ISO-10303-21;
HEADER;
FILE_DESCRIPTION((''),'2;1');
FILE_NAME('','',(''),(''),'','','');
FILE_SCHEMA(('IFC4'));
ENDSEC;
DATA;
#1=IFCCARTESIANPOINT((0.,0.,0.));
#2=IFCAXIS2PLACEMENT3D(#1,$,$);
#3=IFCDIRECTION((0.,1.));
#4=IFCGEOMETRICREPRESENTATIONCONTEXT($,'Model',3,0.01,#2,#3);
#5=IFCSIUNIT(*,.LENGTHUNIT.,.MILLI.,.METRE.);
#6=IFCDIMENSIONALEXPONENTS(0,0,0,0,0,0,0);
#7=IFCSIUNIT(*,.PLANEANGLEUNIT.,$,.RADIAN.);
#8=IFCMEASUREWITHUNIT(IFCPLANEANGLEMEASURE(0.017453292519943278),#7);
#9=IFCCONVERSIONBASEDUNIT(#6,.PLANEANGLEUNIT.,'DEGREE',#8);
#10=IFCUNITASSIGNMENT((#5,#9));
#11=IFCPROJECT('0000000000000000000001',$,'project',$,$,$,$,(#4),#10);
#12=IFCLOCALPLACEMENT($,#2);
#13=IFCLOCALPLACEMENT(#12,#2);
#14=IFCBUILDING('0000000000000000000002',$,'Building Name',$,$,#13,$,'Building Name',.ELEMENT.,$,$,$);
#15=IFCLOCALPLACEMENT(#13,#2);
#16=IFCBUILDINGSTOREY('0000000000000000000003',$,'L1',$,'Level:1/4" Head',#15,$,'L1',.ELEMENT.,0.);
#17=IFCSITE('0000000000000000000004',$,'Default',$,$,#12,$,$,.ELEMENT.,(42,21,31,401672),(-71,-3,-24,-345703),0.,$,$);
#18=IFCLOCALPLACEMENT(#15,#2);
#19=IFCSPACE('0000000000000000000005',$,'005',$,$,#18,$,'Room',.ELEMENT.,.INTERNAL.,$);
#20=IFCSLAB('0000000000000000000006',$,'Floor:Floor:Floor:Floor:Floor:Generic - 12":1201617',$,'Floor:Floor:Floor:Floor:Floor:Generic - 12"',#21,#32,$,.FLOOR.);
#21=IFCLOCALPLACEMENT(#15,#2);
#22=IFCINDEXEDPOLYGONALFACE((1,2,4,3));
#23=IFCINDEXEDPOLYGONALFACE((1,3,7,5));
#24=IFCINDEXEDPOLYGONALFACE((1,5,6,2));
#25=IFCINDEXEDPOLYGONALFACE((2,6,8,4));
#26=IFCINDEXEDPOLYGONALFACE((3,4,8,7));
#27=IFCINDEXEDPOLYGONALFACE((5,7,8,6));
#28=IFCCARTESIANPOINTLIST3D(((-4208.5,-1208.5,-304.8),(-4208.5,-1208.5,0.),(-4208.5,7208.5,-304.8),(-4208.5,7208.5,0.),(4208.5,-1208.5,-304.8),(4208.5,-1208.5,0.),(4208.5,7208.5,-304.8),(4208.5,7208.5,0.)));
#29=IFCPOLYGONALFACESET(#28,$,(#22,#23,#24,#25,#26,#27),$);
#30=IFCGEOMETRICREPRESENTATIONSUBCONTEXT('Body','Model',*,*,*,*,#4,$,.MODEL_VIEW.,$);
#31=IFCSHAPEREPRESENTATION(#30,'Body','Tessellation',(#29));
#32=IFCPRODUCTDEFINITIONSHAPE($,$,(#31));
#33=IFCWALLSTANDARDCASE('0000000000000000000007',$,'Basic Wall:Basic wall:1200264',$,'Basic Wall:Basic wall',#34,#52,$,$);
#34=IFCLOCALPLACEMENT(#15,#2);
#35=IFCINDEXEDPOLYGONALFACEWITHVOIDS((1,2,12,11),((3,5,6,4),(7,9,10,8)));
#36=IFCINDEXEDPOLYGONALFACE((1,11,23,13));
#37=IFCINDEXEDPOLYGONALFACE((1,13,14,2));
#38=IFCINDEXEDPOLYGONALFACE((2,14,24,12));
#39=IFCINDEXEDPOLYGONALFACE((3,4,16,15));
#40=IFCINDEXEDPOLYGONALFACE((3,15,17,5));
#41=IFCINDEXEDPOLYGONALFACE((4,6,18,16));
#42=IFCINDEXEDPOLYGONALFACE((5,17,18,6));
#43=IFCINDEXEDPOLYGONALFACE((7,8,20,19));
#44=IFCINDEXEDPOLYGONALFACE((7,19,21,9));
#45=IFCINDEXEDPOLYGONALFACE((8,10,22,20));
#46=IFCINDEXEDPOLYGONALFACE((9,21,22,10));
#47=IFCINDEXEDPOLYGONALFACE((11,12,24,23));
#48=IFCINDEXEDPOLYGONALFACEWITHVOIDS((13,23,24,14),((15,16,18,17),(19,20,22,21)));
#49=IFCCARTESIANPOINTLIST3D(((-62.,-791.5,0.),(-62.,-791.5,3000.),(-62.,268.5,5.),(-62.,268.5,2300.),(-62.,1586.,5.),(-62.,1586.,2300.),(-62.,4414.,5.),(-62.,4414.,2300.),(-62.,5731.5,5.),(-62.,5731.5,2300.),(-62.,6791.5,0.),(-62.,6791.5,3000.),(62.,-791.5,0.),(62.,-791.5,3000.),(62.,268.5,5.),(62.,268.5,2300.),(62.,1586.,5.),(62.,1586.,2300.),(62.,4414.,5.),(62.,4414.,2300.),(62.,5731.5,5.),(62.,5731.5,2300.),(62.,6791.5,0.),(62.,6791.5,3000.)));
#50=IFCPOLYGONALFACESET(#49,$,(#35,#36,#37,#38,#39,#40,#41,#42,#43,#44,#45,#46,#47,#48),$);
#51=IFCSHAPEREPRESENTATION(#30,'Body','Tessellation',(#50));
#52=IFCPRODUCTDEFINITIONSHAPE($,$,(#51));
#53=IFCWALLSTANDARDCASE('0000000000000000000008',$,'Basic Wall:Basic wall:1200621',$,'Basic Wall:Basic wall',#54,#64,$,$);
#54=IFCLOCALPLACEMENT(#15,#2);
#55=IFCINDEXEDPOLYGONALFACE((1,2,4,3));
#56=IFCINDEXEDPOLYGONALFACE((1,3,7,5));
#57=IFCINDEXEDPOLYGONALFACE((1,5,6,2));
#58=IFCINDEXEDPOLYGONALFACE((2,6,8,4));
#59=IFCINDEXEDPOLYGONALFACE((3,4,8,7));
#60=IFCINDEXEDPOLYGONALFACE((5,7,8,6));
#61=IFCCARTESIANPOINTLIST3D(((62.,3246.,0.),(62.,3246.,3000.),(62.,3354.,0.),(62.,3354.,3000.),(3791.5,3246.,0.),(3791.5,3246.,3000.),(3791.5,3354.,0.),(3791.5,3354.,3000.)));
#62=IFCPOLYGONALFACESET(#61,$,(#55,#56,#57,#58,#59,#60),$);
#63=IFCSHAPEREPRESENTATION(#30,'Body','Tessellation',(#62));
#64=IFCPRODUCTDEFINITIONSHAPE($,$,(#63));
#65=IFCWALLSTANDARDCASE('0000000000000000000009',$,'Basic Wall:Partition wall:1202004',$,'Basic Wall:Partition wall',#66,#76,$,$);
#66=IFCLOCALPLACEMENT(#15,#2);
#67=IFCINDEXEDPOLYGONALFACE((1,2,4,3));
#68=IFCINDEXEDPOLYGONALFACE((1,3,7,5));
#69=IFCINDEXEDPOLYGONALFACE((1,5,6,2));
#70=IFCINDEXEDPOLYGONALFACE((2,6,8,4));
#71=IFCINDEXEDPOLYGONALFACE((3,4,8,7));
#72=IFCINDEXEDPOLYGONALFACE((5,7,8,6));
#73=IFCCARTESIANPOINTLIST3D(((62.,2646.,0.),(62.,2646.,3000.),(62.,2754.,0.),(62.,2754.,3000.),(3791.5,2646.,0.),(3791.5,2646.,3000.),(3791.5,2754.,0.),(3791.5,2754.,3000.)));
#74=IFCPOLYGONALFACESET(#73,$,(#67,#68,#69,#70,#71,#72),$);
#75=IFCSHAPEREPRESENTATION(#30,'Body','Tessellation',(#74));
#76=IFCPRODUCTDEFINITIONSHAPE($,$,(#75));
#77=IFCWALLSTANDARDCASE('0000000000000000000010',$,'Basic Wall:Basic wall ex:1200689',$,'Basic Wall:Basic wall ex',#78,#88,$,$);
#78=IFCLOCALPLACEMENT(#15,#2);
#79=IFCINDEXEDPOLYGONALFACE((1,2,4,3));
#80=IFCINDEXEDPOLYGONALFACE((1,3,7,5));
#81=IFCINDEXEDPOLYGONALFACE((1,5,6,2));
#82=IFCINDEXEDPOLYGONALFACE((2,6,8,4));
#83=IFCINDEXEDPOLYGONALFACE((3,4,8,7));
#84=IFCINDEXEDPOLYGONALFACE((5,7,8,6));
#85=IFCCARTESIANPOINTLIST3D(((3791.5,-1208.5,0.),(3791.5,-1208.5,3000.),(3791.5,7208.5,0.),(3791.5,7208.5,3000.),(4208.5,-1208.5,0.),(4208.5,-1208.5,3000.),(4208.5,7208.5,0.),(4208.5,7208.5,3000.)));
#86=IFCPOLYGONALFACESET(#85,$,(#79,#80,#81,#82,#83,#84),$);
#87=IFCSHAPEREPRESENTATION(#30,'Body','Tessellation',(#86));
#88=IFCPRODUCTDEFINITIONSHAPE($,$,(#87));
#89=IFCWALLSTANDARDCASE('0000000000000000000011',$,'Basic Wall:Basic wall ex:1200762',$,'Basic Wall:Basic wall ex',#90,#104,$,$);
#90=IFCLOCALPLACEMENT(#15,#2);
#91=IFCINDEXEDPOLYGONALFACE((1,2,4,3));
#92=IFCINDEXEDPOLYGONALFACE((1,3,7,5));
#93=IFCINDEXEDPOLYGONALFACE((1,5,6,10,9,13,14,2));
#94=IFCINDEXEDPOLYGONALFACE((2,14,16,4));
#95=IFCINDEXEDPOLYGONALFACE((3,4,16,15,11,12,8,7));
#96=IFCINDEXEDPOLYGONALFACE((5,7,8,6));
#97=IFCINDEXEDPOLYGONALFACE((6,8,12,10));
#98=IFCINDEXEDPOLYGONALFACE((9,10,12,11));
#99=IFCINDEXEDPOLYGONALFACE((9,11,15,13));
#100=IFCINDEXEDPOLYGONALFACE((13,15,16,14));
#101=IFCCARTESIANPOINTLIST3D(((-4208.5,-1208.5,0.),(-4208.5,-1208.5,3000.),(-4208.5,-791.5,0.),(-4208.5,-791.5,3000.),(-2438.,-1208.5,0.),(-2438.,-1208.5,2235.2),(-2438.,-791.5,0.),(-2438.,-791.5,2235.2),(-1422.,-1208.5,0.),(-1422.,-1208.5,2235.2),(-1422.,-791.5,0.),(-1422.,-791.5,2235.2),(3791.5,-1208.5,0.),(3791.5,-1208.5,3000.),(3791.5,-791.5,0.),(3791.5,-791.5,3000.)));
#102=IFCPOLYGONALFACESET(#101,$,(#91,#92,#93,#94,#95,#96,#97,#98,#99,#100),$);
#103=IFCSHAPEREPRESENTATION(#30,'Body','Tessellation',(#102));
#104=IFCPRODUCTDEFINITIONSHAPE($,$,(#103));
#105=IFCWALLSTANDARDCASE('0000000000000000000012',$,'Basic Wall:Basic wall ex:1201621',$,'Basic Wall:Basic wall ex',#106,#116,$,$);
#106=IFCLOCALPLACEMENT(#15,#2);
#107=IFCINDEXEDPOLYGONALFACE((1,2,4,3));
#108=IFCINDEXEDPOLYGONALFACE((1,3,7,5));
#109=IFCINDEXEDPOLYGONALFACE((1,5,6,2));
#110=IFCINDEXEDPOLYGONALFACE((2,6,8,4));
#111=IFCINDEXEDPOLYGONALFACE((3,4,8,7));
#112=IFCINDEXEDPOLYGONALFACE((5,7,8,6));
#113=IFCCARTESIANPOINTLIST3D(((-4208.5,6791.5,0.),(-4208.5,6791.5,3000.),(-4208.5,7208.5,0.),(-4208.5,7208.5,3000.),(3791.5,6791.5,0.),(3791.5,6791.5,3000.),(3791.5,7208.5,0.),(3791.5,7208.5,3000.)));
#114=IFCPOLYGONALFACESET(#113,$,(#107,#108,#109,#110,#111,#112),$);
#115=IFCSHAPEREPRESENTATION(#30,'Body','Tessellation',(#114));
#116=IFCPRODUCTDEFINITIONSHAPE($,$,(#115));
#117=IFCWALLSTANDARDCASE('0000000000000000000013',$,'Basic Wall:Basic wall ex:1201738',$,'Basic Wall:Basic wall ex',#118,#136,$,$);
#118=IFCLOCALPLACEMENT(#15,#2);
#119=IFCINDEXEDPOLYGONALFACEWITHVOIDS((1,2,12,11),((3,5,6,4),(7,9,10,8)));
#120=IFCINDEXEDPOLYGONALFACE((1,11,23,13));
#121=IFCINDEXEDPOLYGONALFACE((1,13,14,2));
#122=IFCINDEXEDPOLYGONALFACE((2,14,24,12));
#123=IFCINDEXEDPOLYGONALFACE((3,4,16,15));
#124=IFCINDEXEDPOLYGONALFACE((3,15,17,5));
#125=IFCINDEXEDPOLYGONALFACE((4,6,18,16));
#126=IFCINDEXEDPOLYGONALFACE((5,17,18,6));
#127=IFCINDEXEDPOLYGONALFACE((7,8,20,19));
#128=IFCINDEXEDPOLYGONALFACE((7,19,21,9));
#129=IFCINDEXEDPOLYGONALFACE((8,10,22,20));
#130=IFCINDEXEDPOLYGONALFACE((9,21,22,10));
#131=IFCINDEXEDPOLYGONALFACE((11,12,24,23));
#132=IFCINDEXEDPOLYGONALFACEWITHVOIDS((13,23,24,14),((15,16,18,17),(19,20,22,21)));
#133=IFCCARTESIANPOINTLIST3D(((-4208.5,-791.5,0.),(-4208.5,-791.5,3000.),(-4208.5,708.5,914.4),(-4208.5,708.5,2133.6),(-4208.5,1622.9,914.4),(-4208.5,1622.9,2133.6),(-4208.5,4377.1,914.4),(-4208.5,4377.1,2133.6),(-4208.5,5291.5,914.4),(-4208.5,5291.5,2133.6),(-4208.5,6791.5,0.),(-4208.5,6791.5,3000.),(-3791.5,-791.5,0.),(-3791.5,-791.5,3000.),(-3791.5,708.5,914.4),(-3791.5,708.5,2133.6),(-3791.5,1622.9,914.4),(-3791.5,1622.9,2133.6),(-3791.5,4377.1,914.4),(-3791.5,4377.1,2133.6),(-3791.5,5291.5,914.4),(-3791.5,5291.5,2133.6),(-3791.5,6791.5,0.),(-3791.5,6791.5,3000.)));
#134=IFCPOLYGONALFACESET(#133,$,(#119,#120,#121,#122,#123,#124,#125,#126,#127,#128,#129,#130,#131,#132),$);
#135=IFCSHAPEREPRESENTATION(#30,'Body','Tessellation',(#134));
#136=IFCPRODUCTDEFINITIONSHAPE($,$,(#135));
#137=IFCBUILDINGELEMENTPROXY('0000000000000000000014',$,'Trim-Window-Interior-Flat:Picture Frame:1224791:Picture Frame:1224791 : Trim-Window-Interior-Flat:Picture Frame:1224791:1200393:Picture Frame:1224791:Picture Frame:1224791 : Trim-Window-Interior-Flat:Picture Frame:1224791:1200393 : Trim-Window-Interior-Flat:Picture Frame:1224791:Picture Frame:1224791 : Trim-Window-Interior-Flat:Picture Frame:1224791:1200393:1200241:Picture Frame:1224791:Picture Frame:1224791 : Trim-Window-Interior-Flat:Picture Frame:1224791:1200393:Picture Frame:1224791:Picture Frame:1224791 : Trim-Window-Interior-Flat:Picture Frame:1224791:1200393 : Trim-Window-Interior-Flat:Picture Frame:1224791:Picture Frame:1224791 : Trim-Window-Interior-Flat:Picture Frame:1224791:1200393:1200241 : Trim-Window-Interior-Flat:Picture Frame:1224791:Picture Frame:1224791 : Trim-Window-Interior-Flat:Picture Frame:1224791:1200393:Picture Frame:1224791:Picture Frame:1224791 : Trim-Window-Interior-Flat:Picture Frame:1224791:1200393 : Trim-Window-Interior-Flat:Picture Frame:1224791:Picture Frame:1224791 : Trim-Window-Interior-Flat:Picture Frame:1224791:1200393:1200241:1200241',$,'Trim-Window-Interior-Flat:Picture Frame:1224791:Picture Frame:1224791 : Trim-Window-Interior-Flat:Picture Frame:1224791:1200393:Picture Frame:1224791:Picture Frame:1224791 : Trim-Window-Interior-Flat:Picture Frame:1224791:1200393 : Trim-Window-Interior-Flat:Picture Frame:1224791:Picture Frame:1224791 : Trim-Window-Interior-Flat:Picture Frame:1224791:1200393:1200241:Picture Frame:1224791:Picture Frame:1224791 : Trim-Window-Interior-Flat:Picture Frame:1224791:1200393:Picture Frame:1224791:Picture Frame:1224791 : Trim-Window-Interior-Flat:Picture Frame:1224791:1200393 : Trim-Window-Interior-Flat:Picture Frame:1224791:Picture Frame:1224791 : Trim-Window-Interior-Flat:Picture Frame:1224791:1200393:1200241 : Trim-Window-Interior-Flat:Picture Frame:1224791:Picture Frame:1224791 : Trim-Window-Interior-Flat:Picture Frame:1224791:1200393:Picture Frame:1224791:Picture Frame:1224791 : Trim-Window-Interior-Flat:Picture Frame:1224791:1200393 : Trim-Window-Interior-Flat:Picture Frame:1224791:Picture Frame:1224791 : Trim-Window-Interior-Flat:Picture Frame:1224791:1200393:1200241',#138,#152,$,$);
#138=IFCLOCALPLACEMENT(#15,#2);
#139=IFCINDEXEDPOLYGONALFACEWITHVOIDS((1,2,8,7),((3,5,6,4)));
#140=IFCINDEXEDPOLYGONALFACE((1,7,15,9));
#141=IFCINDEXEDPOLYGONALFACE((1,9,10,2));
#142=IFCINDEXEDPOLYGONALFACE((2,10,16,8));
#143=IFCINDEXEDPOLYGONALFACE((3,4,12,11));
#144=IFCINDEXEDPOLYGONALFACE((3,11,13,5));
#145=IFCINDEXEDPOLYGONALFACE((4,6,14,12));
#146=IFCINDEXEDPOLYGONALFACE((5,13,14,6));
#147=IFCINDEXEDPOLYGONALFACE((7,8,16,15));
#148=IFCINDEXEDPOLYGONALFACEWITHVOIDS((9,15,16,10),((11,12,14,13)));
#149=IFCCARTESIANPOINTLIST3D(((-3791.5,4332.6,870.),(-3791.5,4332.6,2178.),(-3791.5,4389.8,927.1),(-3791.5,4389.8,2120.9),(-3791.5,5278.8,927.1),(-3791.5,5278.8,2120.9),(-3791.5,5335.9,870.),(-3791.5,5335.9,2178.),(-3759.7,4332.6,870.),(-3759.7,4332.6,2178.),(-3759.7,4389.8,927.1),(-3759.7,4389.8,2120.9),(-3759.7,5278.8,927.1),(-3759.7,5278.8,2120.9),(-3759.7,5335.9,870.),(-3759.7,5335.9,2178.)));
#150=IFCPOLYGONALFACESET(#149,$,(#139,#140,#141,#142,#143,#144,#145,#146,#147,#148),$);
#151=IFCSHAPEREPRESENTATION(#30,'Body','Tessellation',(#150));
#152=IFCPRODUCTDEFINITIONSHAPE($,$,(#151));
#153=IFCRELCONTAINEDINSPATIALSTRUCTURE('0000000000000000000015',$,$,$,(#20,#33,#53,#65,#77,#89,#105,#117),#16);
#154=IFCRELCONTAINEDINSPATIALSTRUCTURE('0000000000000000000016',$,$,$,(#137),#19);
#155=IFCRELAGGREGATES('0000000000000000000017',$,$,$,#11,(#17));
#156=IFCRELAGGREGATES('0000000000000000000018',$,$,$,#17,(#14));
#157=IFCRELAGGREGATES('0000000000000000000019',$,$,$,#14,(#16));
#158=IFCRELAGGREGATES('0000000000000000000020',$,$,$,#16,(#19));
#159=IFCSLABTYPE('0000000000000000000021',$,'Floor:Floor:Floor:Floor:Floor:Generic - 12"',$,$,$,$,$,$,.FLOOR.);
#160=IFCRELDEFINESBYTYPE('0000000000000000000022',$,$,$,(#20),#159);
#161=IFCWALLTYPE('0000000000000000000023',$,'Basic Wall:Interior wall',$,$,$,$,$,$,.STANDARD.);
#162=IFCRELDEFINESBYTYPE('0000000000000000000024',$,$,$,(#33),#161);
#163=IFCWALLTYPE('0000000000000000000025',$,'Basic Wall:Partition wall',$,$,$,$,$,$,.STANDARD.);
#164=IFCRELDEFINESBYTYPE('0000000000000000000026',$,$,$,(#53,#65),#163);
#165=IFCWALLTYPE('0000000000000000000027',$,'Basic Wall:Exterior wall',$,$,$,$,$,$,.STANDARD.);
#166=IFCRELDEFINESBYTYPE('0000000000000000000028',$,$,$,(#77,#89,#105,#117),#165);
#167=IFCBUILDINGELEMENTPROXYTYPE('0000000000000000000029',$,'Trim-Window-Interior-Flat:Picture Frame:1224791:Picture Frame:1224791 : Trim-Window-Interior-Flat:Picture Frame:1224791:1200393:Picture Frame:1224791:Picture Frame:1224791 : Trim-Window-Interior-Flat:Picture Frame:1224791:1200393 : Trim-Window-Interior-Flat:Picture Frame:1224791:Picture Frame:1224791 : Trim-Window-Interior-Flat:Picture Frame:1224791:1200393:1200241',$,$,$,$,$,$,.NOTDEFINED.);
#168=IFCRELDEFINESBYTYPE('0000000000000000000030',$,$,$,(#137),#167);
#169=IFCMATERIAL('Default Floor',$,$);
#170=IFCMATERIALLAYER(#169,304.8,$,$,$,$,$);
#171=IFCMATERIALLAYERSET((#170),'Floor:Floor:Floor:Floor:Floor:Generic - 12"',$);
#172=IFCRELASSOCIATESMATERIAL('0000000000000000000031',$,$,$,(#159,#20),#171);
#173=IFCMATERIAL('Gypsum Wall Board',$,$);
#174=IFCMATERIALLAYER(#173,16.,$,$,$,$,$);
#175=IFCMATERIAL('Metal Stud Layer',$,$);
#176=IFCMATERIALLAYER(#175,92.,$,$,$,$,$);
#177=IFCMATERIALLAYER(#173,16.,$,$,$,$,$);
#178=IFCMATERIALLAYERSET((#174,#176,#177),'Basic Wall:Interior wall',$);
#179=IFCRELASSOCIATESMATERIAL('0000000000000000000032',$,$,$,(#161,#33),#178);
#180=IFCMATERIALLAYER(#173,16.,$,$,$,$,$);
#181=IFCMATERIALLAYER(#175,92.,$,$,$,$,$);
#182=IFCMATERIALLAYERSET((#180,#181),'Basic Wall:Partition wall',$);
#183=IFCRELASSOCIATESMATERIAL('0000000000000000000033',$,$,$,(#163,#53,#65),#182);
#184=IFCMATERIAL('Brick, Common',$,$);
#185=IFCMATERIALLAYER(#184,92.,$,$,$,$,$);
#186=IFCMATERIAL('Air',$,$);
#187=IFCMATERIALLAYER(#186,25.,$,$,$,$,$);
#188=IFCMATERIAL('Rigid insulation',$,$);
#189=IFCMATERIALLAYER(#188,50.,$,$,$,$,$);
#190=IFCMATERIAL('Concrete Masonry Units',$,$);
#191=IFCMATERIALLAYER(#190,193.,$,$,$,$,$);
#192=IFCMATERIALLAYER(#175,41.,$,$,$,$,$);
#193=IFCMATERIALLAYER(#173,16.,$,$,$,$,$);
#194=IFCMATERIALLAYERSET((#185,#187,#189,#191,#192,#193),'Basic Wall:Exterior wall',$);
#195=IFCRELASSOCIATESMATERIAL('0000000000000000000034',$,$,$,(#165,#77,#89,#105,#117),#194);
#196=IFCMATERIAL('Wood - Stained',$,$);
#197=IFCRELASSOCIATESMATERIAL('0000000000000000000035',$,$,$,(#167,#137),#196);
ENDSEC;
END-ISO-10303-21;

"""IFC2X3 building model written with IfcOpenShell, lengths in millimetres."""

from ifc_helpers import new_model, entity, si_unit, converted_unit, direction, frame, frame_2d, origin, origin_2d_with_axis, place, context, subcontext, project, spatial, polyline, rectangle, outline, extrude, source, transform, mapped, material, layer, layer_set, layer_usage, type_object, type_shapes, element, save


model = new_model("IFC2X3")

# Units and contexts
model_context = context("Model", 3, precision=0.01, world=origin(), true_north=direction((0.0, 1.0)))
body_context = subcontext(model_context, "Body", "Model", "MODEL_VIEW")
ifc_project = project(units=[si_unit("LENGTHUNIT", "METRE", prefix="MILLI"), converted_unit("PLANEANGLEUNIT", "DEGREE", entity("IfcPlaneAngleMeasure", 0.017453292519943278), si_unit("PLANEANGLEUNIT", "RADIAN"), dimensions=[0, 0, 0, 0, 0, 0, 0])], contexts=[model_context])

# Site, building, storey
site_placement = place(None, origin())
site = spatial("IfcSite", under=ifc_project, at=site_placement, Name="Default", CompositionType="ELEMENT", RefLatitude=(42, 21, 31, 401672), RefLongitude=(-71, -3, -24, -345703), RefElevation=0.0)
building_placement = place(site_placement, origin())
building = spatial("IfcBuilding", under=site, at=building_placement, Name="Building Name", LongName="Building Name", CompositionType="ELEMENT")
storey_placement = place(building_placement, origin())
storey = spatial("IfcBuildingStorey", under=building, at=storey_placement, Name="L1", ObjectType="Level:1/4\" Head", LongName="L1", CompositionType="ELEMENT", Elevation=0.0)

# Slab
ifc_material_1 = material(Name="Default Floor")
ifc_layer_1 = layer(ifc_material_1, 304.8)
ifc_layer_set_1 = layer_set([ifc_layer_1], Name="Floor:Floor:Floor:Floor:Floor:Generic - 12\"")
ifc_layer_usage_1 = layer_usage(ifc_layer_set_1, "AXIS3", "POSITIVE", 0.0)
slab_type = type_object("IfcSlabType", Name="Floor:Floor:Floor:Floor:Floor:Generic - 12\"", PredefinedType="FLOOR", material=ifc_layer_set_1)
slab_placement = place(storey_placement, origin())
element("IfcSlab", 1, at=slab_placement, inside=storey, type_object=slab_type, material=ifc_layer_usage_1, Name="Floor:Floor:Floor:Floor:Floor:Generic - 12\":1201617", ObjectType="Floor:Floor:Floor:Floor:Floor:Generic - 12\"", PredefinedType="FLOOR", context=body_context, shape_type="SweptSolid", body=[
    extrude(rectangle(XDim=8417.0, YDim=8417.0, at=origin_2d_with_axis()), frame((0.0, 3000.0, 0.0), z_axis=(0.0, 0.0, -1.0), x_axis=(0.0, 1.0, 0.0)), (0.0, 0.0, 1.0), 304.8),
])

# Wall, openings
ifc_material_2 = material(Name="Gypsum Wall Board")
ifc_layer_2 = layer(ifc_material_2, 16.0)
ifc_material_3 = material(Name="Metal Stud Layer")
ifc_layer_3 = layer(ifc_material_3, 92.0)
ifc_layer_4 = layer(ifc_material_2, 16.0)
ifc_layer_set_2 = layer_set([ifc_layer_2, ifc_layer_3, ifc_layer_4], Name="Basic Wall:Interior wall")
ifc_layer_usage_2 = layer_usage(ifc_layer_set_2, "AXIS2", "NEGATIVE", 62.0)
wall_type_1 = type_object("IfcWallType", Name="Basic Wall:Interior wall", PredefinedType="STANDARD", material=ifc_layer_set_2)
wall_1_placement = place(storey_placement, frame((0.0, 6791.5, 0.0), z_axis=(0.0, 0.0, 1.0), x_axis=(0.0, -1.0, 0.0)))
wall_1 = element("IfcWallStandardCase", 2, at=wall_1_placement, inside=storey, type_object=wall_type_1, material=ifc_layer_usage_2, Name="Basic Wall:Basic wall:1200264", ObjectType="Basic Wall:Basic wall", context=body_context, shape_type="SweptSolid", body=[
    extrude(rectangle(XDim=7583.0, YDim=124.0, at=frame_2d((3791.5, 0.0), x_axis=(-1.0, 0.0))), origin(), (0.0, 0.0, 1.0), 3000.0),
])
opening_1_placement = place(wall_1_placement, origin())
element("IfcOpeningElement", 3, at=opening_1_placement, cuts=wall_1, ObjectType="Opening", context=body_context, shape_type="SweptSolid", body=[
    extrude(rectangle(XDim=2295.0, YDim=1317.5, at=origin_2d_with_axis()), frame((1718.7, -62.0, 1152.5), z_axis=(0.0, 1.0, 0.0), x_axis=(0.0, 0.0, -1.0)), (0.0, 0.0, 1.0), 124.0),
])
opening_2_placement = place(wall_1_placement, origin())
element("IfcOpeningElement", 4, at=opening_2_placement, cuts=wall_1, ObjectType="Opening", context=body_context, shape_type="SweptSolid", body=[
    extrude(rectangle(XDim=2295.0, YDim=1317.5, at=origin_2d_with_axis()), frame((5864.2, -62.0, 1152.5), z_axis=(0.0, 1.0, 0.0), x_axis=(0.0, 0.0, -1.0)), (0.0, 0.0, 1.0), 124.0),
])

# Walls
ifc_layer_5 = layer(ifc_material_2, 16.0)
ifc_layer_6 = layer(ifc_material_3, 92.0)
ifc_layer_set_3 = layer_set([ifc_layer_5, ifc_layer_6], Name="Basic Wall:Partition wall")
ifc_layer_usage_3 = layer_usage(ifc_layer_set_3, "AXIS2", "NEGATIVE", 54.0)
wall_type_2 = type_object("IfcWallType", Name="Basic Wall:Partition wall", PredefinedType="STANDARD", material=ifc_layer_set_3)
wall_2_placement = place(storey_placement, frame((62.0, 3300.0, 0.0)))
element("IfcWallStandardCase", 5, at=wall_2_placement, inside=storey, type_object=wall_type_2, material=ifc_layer_usage_3, Name="Basic Wall:Basic wall:1200621", ObjectType="Basic Wall:Basic wall", context=body_context, shape_type="SweptSolid", body=[
    extrude(rectangle(XDim=3729.5, YDim=108.0, at=frame_2d((1864.8, 0.0), x_axis=(-1.0, 0.0))), origin(), (0.0, 0.0, 1.0), 3000.0),
])
ifc_layer_usage_4 = layer_usage(ifc_layer_set_3, "AXIS2", "NEGATIVE", 54.0)
wall_3_placement = place(storey_placement, frame((3791.5, 2700.0, 0.0), z_axis=(0.0, 0.0, 1.0), x_axis=(-1.0, 0.0, 0.0)))
element("IfcWallStandardCase", 6, at=wall_3_placement, inside=storey, type_object=wall_type_2, material=ifc_layer_usage_4, Name="Basic Wall:Partition wall:1202004", ObjectType="Basic Wall:Partition wall", context=body_context, shape_type="SweptSolid", body=[
    extrude(rectangle(XDim=3729.5, YDim=108.0, at=frame_2d((1864.8, 0.0), x_axis=(-1.0, 0.0))), origin(), (0.0, 0.0, 1.0), 3000.0),
])
ifc_material_4 = material(Name="Brick, Common")
ifc_layer_7 = layer(ifc_material_4, 92.0)
ifc_material_5 = material(Name="Air")
ifc_layer_8 = layer(ifc_material_5, 25.0)
ifc_material_6 = material(Name="Rigid insulation")
ifc_layer_9 = layer(ifc_material_6, 50.0)
ifc_material_7 = material(Name="Concrete Masonry Units")
ifc_layer_10 = layer(ifc_material_7, 193.0)
ifc_layer_11 = layer(ifc_material_3, 41.0)
ifc_layer_12 = layer(ifc_material_2, 16.0)
ifc_layer_set_4 = layer_set([ifc_layer_7, ifc_layer_8, ifc_layer_9, ifc_layer_10, ifc_layer_11, ifc_layer_12], Name="Basic Wall:Exterior wall")
ifc_layer_usage_5 = layer_usage(ifc_layer_set_4, "AXIS2", "NEGATIVE", 208.5)
wall_type_3 = type_object("IfcWallType", Name="Basic Wall:Exterior wall", PredefinedType="STANDARD", material=ifc_layer_set_4)
wall_4_placement = place(storey_placement, frame((4000.0, 7208.5, 0.0), z_axis=(0.0, 0.0, 1.0), x_axis=(0.0, -1.0, 0.0)))
element("IfcWallStandardCase", 7, at=wall_4_placement, inside=storey, type_object=wall_type_3, material=ifc_layer_usage_5, Name="Basic Wall:Basic wall ex:1200689", ObjectType="Basic Wall:Basic wall ex", context=body_context, shape_type="SweptSolid", body=[
    extrude(rectangle(XDim=8417.0, YDim=417.0, at=frame_2d((4208.5, 0.0), x_axis=(-1.0, 0.0))), origin(), (0.0, 0.0, 1.0), 3000.0),
])

# Wall, opening
ifc_layer_usage_6 = layer_usage(ifc_layer_set_4, "AXIS2", "NEGATIVE", 208.5)
wall_5_placement = place(storey_placement, frame((3791.5, -1000.0, 0.0), z_axis=(0.0, 0.0, 1.0), x_axis=(-1.0, 0.0, 0.0)))
wall_5 = element("IfcWallStandardCase", 8, at=wall_5_placement, inside=storey, type_object=wall_type_3, material=ifc_layer_usage_6, Name="Basic Wall:Basic wall ex:1200762", ObjectType="Basic Wall:Basic wall ex", context=body_context, shape_type="SweptSolid", body=[
    extrude(rectangle(XDim=8000.0, YDim=417.0, at=frame_2d((4000.0, 0.0), x_axis=(1.0, 0.0))), origin(), (0.0, 0.0, 1.0), 3000.0),
])
opening_3_placement = place(wall_5_placement, frame((3791.5, -1000.0, 0.0), z_axis=(0.0, 0.0, 1.0), x_axis=(-1.0, 0.0, 0.0)))
element("IfcOpeningElement", 9, at=opening_3_placement, cuts=wall_5, ObjectType="Opening", context=body_context, shape_type="SweptSolid", body=[
    extrude(rectangle(XDim=2235.2, YDim=1016.0, at=frame_2d((0.0, 0.0), x_axis=(0.0, 1.0))), frame((-1930.0, -778.7, 1117.6), z_axis=(0.0, -1.0, 0.0), x_axis=(-1.0, 0.0, 0.0)), (0.0, 0.0, 1.0), 442.5),
])

# Wall
ifc_layer_usage_7 = layer_usage(ifc_layer_set_4, "AXIS2", "NEGATIVE", 208.5)
wall_6_placement = place(storey_placement, frame((-4208.5, 7000.0, 0.0)))
element("IfcWallStandardCase", 10, at=wall_6_placement, inside=storey, type_object=wall_type_3, material=ifc_layer_usage_7, Name="Basic Wall:Basic wall ex:1201621", ObjectType="Basic Wall:Basic wall ex", context=body_context, shape_type="SweptSolid", body=[
    extrude(rectangle(XDim=8000.0, YDim=417.0, at=frame_2d((4000.0, 0.0), x_axis=(-1.0, 0.0))), origin(), (0.0, 0.0, 1.0), 3000.0),
])

# Wall, openings
ifc_layer_usage_8 = layer_usage(ifc_layer_set_4, "AXIS2", "NEGATIVE", 208.5)
wall_7_placement = place(storey_placement, frame((-4000.0, -791.5, 0.0), z_axis=(0.0, 0.0, 1.0), x_axis=(0.0, 1.0, 0.0)))
wall_7 = element("IfcWallStandardCase", 11, at=wall_7_placement, inside=storey, type_object=wall_type_3, material=ifc_layer_usage_8, Name="Basic Wall:Basic wall ex:1201738", ObjectType="Basic Wall:Basic wall ex", context=body_context, shape_type="SweptSolid", body=[
    extrude(rectangle(XDim=7583.0, YDim=417.0, at=frame_2d((3791.5, 0.0), x_axis=(-1.0, 0.0))), origin(), (0.0, 0.0, 1.0), 3000.0),
])
opening_4_placement = place(wall_7_placement, frame((791.5, -4000.0, 0.0), z_axis=(0.0, 0.0, 1.0), x_axis=(0.0, -1.0, 0.0)))
element("IfcOpeningElement", 12, at=opening_4_placement, cuts=wall_7, ObjectType="Opening", context=body_context, shape_type="SweptSolid", body=[
    extrude(rectangle(XDim=1219.2, YDim=914.4, at=frame_2d((0.0, 0.0), x_axis=(0.0, 1.0))), frame((-3778.7, 4834.3, 1524.0), z_axis=(-1.0, 0.0, 0.0), x_axis=(0.0, -1.0, 0.0)), (0.0, 0.0, 1.0), 442.5),
])
opening_5_placement = place(wall_7_placement, frame((791.5, -4000.0, 0.0), z_axis=(0.0, 0.0, 1.0), x_axis=(0.0, -1.0, 0.0)))
element("IfcOpeningElement", 13, at=opening_5_placement, cuts=wall_7, ObjectType="Opening", context=body_context, shape_type="SweptSolid", body=[
    extrude(rectangle(XDim=1219.2, YDim=914.4, at=frame_2d((0.0, 0.0), x_axis=(0.0, 1.0))), frame((-3778.7, 1165.7, 1524.0), z_axis=(-1.0, 0.0, 0.0), x_axis=(0.0, -1.0, 0.0)), (0.0, 0.0, 1.0), 442.5),
])

# Shared definitions
space_placement = place(storey_placement, origin())
space = spatial("IfcSpace", under=storey, at=space_placement, Name="005", LongName="Room", CompositionType="ELEMENT", InteriorOrExteriorSpace="INTERNAL")

# Building element proxy
ifc_material_8 = material(Name="Wood - Stained")
building_element_proxy_type_1 = type_object("IfcBuildingElementProxyType", Name="Trim-Window-Interior-Flat:Picture Frame:1224791:Picture Frame:1224791 : Trim-Window-Interior-Flat:Picture Frame:1224791:1200393:Picture Frame:1224791:Picture Frame:1224791 : Trim-Window-Interior-Flat:Picture Frame:1224791:1200393 : Trim-Window-Interior-Flat:Picture Frame:1224791:Picture Frame:1224791 : Trim-Window-Interior-Flat:Picture Frame:1224791:1200393:1200241", PredefinedType="NOTDEFINED", material=ifc_material_8)
shared_shape_1 = source(origin(), body_context, "Body", "SweptSolid", [
    extrude(outline(polyline([(-654.0, -501.6), (654.0, -501.6), (654.0, 501.6), (-654.0, 501.6), (-654.0, -501.6)]), holes=[polyline([(596.9, 444.5), (596.9, -444.5), (-596.9, -444.5), (-596.9, 444.5), (596.9, 444.5)])]), frame((-3791.5, 4834.3, 1524.0), z_axis=(1.0, 0.0, 0.0), x_axis=(0.0, 0.0, 1.0)), (0.0, 0.0, 1.0), 31.7),
])
type_shapes(building_element_proxy_type_1, [shared_shape_1])
proxy_1_placement = place(space_placement, origin())
element("IfcBuildingElementProxy", 14, at=proxy_1_placement, inside=space, type_object=building_element_proxy_type_1, material=ifc_material_8, Name="Trim-Window-Interior-Flat:Picture Frame:1224791:Picture Frame:1224791 : Trim-Window-Interior-Flat:Picture Frame:1224791:1200393:Picture Frame:1224791:Picture Frame:1224791 : Trim-Window-Interior-Flat:Picture Frame:1224791:1200393 : Trim-Window-Interior-Flat:Picture Frame:1224791:Picture Frame:1224791 : Trim-Window-Interior-Flat:Picture Frame:1224791:1200393:1200241:Picture Frame:1224791:Picture Frame:1224791 : Trim-Window-Interior-Flat:Picture Frame:1224791:1200393:Picture Frame:1224791:Picture Frame:1224791 : Trim-Window-Interior-Flat:Picture Frame:1224791:1200393 : Trim-Window-Interior-Flat:Picture Frame:1224791:Picture Frame:1224791 : Trim-Window-Interior-Flat:Picture Frame:1224791:1200393:1200241 : Trim-Window-Interior-Flat:Picture Frame:1224791:Picture Frame:1224791 : Trim-Window-Interior-Flat:Picture Frame:1224791:1200393:Picture Frame:1224791:Picture Frame:1224791 : Trim-Window-Interior-Flat:Picture Frame:1224791:1200393 : Trim-Window-Interior-Flat:Picture Frame:1224791:Picture Frame:1224791 : Trim-Window-Interior-Flat:Picture Frame:1224791:1200393:1200241:1200241", ObjectType="Trim-Window-Interior-Flat:Picture Frame:1224791:Picture Frame:1224791 : Trim-Window-Interior-Flat:Picture Frame:1224791:1200393:Picture Frame:1224791:Picture Frame:1224791 : Trim-Window-Interior-Flat:Picture Frame:1224791:1200393 : Trim-Window-Interior-Flat:Picture Frame:1224791:Picture Frame:1224791 : Trim-Window-Interior-Flat:Picture Frame:1224791:1200393:1200241:Picture Frame:1224791:Picture Frame:1224791 : Trim-Window-Interior-Flat:Picture Frame:1224791:1200393:Picture Frame:1224791:Picture Frame:1224791 : Trim-Window-Interior-Flat:Picture Frame:1224791:1200393 : Trim-Window-Interior-Flat:Picture Frame:1224791:Picture Frame:1224791 : Trim-Window-Interior-Flat:Picture Frame:1224791:1200393:1200241 : Trim-Window-Interior-Flat:Picture Frame:1224791:Picture Frame:1224791 : Trim-Window-Interior-Flat:Picture Frame:1224791:1200393:Picture Frame:1224791:Picture Frame:1224791 : Trim-Window-Interior-Flat:Picture Frame:1224791:1200393 : Trim-Window-Interior-Flat:Picture Frame:1224791:Picture Frame:1224791 : Trim-Window-Interior-Flat:Picture Frame:1224791:1200393:1200241", context=body_context, shape_type="MappedRepresentation", body=[
    mapped(shared_shape_1, transform((0.0, 0.0, 0.0), scale=1.0)),
])

save(model, "model.ifc")
